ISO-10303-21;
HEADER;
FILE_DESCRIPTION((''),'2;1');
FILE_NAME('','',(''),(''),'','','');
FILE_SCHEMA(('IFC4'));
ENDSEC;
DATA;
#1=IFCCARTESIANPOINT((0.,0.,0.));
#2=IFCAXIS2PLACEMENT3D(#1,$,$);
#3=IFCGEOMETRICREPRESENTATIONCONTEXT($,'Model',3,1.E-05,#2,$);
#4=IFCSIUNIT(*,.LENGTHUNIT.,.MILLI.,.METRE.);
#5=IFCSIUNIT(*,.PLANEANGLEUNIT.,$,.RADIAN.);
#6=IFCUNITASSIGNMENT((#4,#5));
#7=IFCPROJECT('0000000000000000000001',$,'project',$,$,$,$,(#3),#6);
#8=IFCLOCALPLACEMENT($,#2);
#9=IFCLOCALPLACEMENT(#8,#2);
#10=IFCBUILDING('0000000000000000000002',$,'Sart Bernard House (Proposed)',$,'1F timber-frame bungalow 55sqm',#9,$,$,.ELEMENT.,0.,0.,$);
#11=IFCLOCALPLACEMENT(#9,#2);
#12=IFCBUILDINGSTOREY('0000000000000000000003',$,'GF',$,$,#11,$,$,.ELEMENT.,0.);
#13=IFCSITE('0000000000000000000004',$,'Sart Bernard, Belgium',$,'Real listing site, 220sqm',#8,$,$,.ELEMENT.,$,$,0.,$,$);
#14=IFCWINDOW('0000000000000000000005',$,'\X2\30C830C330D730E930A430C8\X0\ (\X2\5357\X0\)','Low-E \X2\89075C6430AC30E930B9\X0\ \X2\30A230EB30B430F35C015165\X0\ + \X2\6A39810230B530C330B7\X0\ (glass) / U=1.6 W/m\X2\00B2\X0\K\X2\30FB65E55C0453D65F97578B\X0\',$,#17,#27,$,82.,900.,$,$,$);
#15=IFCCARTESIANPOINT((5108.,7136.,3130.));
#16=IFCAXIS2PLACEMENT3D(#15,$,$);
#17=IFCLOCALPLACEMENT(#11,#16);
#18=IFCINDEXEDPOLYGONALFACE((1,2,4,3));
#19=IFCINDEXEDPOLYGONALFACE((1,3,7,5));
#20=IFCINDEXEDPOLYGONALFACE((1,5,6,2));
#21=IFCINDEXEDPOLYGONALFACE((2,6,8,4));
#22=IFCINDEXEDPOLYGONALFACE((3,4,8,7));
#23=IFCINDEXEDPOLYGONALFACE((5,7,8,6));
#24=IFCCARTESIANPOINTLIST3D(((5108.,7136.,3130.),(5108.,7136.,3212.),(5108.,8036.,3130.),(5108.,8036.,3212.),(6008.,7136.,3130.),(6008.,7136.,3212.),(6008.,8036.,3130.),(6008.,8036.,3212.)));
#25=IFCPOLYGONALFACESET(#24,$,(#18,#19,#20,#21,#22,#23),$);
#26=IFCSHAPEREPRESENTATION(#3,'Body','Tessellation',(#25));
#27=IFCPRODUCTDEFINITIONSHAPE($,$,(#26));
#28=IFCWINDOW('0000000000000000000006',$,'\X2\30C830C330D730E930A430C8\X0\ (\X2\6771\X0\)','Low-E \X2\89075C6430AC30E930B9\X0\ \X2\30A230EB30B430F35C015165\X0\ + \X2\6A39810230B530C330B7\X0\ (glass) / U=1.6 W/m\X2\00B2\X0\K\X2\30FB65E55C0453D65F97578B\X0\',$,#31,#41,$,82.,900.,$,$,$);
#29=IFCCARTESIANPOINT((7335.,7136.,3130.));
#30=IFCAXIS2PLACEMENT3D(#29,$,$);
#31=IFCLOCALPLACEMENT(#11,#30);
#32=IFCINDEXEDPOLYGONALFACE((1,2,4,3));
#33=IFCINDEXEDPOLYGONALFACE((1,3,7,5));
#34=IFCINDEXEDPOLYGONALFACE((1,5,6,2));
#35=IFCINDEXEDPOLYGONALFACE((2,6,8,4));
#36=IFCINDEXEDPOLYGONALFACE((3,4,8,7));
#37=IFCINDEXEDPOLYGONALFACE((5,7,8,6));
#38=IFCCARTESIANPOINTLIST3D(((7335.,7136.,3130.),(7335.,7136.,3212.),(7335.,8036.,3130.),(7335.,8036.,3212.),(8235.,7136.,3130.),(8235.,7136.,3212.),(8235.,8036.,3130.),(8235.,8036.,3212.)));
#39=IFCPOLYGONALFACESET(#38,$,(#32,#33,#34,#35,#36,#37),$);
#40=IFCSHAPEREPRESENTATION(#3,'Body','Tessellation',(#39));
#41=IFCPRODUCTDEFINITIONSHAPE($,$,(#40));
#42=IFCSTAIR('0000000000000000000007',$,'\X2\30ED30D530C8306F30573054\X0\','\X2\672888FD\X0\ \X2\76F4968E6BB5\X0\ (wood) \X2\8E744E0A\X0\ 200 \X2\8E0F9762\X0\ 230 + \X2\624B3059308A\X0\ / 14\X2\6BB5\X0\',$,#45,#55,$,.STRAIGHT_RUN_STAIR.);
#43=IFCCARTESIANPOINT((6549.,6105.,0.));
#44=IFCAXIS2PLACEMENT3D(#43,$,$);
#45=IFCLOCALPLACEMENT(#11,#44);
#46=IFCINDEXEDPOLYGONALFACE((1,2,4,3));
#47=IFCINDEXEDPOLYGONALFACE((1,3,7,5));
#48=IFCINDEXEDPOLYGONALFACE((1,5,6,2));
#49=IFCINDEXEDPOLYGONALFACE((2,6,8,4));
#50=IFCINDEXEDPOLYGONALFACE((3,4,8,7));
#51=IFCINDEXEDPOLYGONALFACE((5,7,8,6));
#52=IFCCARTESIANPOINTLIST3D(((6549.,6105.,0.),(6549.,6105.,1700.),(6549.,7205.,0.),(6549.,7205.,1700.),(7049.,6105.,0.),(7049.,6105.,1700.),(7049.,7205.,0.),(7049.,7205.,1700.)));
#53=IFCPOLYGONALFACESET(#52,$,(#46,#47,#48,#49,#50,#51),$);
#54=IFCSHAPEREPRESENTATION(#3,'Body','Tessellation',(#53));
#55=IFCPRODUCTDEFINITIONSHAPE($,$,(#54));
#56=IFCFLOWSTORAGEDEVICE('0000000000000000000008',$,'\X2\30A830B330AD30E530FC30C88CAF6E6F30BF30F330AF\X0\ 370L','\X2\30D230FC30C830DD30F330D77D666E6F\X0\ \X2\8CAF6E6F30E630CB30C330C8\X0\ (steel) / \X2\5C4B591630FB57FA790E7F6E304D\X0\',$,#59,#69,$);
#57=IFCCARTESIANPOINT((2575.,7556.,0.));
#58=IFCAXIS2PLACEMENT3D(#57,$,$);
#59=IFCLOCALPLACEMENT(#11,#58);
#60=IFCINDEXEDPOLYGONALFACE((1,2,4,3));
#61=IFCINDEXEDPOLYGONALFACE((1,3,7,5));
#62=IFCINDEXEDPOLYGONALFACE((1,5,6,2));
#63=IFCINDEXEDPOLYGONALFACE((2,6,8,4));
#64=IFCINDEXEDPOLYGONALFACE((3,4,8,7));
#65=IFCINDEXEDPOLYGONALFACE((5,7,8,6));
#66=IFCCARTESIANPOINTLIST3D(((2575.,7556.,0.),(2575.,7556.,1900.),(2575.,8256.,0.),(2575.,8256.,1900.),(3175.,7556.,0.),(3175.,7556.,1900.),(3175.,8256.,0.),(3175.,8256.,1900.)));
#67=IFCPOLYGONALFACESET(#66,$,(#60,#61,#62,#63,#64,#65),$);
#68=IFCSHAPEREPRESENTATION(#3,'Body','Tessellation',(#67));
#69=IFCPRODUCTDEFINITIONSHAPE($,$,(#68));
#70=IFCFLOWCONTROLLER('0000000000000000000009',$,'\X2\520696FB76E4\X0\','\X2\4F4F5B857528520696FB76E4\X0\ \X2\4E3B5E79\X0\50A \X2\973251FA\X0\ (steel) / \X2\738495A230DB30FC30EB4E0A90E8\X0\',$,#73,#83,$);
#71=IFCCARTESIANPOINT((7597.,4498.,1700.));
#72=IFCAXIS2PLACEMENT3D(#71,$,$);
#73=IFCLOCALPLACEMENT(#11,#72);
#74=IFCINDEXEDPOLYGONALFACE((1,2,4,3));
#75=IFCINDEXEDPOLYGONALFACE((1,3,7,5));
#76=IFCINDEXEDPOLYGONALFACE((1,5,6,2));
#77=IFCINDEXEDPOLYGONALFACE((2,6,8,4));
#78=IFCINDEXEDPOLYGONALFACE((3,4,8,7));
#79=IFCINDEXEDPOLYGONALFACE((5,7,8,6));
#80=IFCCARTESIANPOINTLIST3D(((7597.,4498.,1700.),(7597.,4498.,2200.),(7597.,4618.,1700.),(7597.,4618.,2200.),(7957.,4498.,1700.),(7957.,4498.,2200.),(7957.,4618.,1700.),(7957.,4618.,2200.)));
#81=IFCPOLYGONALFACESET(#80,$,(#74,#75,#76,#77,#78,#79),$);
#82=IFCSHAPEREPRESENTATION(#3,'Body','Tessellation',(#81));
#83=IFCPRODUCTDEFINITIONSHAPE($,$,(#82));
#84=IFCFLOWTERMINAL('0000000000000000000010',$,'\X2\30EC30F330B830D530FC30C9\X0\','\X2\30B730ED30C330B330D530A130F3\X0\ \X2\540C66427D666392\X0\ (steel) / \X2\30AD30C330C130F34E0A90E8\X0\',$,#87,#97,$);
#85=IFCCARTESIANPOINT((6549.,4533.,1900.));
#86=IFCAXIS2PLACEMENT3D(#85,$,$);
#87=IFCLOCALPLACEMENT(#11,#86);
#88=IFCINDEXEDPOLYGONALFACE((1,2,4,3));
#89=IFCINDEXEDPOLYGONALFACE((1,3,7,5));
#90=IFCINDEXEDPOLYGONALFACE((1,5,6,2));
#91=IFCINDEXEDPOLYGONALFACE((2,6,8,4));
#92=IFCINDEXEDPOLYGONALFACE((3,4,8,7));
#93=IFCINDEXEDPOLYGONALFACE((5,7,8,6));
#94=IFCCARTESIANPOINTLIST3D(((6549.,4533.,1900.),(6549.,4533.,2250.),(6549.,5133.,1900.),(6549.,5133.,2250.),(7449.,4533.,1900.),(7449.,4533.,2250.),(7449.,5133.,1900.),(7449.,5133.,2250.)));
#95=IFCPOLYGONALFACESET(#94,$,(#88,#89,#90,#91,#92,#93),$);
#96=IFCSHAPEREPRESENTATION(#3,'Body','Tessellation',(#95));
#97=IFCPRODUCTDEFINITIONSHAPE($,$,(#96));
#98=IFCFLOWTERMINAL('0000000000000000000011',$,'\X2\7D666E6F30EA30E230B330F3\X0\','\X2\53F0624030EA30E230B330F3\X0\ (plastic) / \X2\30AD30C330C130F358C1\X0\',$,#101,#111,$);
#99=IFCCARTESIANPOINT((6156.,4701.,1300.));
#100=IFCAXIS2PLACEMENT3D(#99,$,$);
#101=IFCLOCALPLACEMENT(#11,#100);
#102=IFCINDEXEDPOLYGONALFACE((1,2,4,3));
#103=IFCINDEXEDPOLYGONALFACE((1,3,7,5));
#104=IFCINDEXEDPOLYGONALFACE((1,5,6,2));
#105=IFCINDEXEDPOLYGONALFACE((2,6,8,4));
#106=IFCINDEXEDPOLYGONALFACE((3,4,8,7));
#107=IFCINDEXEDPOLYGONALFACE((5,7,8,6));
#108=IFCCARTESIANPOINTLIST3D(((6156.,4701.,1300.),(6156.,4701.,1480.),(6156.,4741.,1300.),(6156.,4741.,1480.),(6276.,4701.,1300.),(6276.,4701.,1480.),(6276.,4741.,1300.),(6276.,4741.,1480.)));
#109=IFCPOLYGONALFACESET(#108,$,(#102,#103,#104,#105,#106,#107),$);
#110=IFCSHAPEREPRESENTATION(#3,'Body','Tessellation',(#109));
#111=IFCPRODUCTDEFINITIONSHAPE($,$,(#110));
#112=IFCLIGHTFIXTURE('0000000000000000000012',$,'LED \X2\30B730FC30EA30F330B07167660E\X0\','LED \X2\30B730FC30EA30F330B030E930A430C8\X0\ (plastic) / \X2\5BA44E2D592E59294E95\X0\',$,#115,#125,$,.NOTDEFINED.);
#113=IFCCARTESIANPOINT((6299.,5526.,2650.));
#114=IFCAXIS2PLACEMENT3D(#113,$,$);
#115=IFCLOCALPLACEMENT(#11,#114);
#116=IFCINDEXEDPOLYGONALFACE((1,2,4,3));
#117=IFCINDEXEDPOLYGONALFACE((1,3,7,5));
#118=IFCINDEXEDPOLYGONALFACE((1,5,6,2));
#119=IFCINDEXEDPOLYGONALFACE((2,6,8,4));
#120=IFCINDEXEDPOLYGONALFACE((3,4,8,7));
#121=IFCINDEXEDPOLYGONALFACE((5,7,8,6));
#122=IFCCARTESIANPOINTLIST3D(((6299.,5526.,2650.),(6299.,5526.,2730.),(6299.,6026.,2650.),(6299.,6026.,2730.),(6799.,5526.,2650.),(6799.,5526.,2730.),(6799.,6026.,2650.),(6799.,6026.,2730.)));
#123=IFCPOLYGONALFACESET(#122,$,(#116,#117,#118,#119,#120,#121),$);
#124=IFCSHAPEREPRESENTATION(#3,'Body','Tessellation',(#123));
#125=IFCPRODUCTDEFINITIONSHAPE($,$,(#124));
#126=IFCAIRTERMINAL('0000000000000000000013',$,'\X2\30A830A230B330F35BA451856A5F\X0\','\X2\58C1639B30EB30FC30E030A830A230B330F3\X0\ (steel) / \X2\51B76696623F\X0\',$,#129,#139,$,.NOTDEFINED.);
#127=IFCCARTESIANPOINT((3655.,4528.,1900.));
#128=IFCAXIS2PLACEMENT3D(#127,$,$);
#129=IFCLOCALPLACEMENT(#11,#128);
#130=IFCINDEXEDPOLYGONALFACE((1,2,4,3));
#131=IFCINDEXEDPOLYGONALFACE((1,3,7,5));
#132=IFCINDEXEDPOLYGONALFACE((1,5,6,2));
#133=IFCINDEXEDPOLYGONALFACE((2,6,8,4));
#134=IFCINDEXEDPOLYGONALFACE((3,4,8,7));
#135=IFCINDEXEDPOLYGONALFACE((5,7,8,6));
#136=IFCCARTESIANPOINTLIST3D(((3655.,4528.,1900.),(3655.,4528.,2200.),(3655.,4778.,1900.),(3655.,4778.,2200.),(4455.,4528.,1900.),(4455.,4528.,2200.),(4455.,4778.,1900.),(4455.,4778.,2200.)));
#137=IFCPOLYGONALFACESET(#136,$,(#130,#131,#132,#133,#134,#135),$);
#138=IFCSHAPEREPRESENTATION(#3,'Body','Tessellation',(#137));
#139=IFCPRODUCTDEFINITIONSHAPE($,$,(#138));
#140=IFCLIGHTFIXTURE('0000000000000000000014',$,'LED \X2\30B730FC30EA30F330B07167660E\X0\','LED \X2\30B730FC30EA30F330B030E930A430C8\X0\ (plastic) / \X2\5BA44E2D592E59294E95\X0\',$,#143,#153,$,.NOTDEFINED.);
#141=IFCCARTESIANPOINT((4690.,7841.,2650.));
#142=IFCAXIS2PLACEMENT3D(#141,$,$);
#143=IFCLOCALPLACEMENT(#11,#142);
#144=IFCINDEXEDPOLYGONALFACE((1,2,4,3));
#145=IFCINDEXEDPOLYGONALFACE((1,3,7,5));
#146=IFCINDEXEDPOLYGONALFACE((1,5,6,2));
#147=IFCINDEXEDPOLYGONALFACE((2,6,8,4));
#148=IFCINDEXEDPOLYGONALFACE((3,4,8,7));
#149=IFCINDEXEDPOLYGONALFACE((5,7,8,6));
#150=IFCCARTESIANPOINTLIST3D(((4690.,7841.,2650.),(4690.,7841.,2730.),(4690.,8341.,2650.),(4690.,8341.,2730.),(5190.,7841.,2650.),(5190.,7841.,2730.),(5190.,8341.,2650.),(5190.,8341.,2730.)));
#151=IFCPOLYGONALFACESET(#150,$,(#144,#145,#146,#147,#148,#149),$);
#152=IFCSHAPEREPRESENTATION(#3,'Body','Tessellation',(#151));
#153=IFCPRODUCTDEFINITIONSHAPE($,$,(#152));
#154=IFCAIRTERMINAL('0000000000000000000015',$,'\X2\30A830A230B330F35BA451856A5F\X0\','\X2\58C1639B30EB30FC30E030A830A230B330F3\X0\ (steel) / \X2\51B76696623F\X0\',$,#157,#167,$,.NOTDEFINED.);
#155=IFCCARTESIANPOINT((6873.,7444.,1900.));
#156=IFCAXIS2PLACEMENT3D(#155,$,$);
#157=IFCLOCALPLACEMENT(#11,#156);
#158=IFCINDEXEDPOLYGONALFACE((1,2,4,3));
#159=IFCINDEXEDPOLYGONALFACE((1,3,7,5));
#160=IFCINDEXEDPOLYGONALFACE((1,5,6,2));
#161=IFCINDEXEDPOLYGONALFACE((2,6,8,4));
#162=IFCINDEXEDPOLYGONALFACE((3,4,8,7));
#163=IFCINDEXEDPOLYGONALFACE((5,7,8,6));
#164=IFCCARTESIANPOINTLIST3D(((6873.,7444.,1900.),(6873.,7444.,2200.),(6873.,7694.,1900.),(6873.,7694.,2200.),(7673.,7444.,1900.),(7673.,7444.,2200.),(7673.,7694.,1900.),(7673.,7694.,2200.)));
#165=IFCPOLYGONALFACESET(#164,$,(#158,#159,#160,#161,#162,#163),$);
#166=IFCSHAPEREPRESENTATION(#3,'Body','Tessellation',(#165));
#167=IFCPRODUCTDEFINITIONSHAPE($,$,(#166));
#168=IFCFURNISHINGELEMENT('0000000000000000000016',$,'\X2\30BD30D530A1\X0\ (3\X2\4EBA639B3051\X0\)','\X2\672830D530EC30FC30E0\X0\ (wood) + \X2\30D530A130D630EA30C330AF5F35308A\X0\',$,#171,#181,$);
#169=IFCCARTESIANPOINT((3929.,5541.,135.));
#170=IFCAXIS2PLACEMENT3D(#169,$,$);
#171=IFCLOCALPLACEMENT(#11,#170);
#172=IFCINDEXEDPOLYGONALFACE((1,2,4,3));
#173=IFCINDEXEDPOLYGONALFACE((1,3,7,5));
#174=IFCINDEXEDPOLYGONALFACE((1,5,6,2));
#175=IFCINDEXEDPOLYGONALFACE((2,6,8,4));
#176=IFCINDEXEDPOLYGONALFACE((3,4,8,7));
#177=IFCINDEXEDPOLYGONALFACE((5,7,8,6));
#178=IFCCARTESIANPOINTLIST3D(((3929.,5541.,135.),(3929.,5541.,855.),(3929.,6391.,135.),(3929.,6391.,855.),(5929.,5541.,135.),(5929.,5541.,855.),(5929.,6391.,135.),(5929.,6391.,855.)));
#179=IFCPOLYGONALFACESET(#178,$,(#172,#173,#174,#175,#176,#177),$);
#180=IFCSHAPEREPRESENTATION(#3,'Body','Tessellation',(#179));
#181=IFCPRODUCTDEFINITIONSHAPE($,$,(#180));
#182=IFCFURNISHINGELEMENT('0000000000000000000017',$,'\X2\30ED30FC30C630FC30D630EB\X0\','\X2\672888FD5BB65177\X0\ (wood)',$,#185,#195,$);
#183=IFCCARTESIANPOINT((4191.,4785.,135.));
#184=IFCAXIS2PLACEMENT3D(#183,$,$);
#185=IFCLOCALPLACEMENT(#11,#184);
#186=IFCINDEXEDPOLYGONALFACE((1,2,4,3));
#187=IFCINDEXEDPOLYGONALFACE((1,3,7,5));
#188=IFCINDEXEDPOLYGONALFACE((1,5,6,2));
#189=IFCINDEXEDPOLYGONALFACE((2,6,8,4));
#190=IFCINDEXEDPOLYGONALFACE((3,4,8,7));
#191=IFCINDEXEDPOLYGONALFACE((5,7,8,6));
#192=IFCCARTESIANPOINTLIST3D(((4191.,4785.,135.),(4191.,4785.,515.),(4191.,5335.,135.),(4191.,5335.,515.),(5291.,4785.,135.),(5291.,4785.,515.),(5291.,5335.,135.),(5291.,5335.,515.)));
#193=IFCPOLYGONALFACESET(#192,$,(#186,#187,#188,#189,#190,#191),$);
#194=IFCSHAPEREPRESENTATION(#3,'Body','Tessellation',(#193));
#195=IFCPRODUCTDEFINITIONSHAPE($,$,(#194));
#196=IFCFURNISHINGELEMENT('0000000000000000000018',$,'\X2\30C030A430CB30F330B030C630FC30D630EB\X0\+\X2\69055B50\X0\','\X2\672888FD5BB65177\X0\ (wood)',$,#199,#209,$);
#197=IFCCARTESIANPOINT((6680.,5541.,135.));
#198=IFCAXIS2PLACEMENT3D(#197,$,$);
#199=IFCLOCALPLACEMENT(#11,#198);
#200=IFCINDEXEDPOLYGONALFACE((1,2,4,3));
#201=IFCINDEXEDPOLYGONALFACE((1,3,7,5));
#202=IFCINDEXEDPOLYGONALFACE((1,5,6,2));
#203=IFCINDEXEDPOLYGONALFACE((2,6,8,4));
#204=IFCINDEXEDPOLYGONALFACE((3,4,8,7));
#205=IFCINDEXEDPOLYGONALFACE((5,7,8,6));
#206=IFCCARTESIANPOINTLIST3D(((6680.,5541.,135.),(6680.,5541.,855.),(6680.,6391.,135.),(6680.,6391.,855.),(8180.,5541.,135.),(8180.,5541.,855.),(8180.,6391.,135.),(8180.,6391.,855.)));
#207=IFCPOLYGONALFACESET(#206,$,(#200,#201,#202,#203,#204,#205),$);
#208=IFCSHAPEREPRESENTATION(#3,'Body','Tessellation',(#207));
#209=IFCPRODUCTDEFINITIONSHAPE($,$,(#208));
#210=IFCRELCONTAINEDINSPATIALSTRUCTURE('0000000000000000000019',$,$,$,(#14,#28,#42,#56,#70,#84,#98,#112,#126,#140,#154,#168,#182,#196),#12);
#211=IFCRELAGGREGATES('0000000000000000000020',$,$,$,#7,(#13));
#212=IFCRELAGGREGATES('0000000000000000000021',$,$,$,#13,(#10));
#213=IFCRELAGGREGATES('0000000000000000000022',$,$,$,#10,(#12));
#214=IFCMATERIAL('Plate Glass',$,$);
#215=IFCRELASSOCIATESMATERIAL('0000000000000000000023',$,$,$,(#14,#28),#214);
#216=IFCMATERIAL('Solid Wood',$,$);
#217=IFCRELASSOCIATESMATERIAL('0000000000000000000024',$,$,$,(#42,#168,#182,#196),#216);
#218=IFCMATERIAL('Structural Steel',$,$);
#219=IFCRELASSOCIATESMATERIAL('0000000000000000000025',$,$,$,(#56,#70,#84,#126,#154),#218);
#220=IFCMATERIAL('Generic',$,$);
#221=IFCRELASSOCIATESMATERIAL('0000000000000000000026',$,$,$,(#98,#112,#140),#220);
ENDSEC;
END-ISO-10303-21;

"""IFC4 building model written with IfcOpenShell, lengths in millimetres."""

from ifc_helpers import new_model, si_unit, frame, frame_2d, origin, place, context, project, spatial, rectangle, extrude, material, element, save


model = new_model("IFC4")

# Units and contexts
model_context = context("Model", 3, precision=1e-05, world=origin())
ifc_project = project(units=[si_unit("LENGTHUNIT", "METRE", prefix="MILLI"), si_unit("PLANEANGLEUNIT", "RADIAN")], contexts=[model_context])

# Site, building, storey
site_placement = place(None, origin())
site = spatial("IfcSite", under=ifc_project, at=site_placement, Name="Sart Bernard, Belgium", ObjectType="Real listing site, 220sqm", CompositionType="ELEMENT", RefElevation=0.0)
building_placement = place(site_placement, origin())
building = spatial("IfcBuilding", under=site, at=building_placement, Name="Sart Bernard House (Proposed)", ObjectType="1F timber-frame bungalow 55sqm", CompositionType="ELEMENT", ElevationOfRefHeight=0.0, ElevationOfTerrain=0.0)
storey_placement = place(building_placement, origin())
storey = spatial("IfcBuildingStorey", under=building, at=storey_placement, Name="GF", CompositionType="ELEMENT", Elevation=0.0)

# Shared definitions
ifc_material_1 = material(Name="Solid Wood")

# Windows
ifc_material_2 = material(Name="Plate Glass")
window_1_placement = place(storey_placement, frame((5108.0, 7136.0, 3130.0)))
element("IfcWindow", 1, at=window_1_placement, inside=storey, material=ifc_material_2, Name="トップライト (南)", Description="Low-E 複層ガラス アルゴン封入 + 樹脂サッシ (glass) / U=1.6 W/m²K・日射取得型", OverallHeight=82.0, OverallWidth=900.0, context=model_context, shape_type="SweptSolid", body=[
    extrude(rectangle(XDim=900.0, YDim=900.0, at=frame_2d((450.0, 450.0))), frame((5108.0, 7136.0, 3130.0)), (0.0, 0.0, 1.0), 82.0),
])
window_2_placement = place(storey_placement, frame((7335.0, 7136.0, 3130.0)))
element("IfcWindow", 2, at=window_2_placement, inside=storey, material=ifc_material_2, Name="トップライト (東)", Description="Low-E 複層ガラス アルゴン封入 + 樹脂サッシ (glass) / U=1.6 W/m²K・日射取得型", OverallHeight=82.0, OverallWidth=900.0, context=model_context, shape_type="SweptSolid", body=[
    extrude(rectangle(XDim=900.0, YDim=900.0, at=frame_2d((450.0, 450.0))), frame((7335.0, 7136.0, 3130.0)), (0.0, 0.0, 1.0), 82.0),
])

# Stair
stair_placement = place(storey_placement, frame((6549.0, 6105.0, 0.0)))
element("IfcStair", 3, at=stair_placement, inside=storey, material=ifc_material_1, Name="ロフトはしご", Description="木製 直階段 (wood) 蹴上 200 踏面 230 + 手すり / 14段", PredefinedType="STRAIGHT_RUN_STAIR", context=model_context, shape_type="SweptSolid", body=[
    extrude(rectangle(XDim=500.0, YDim=1100.0, at=frame_2d((250.0, 550.0))), frame((6549.0, 6105.0, 0.0)), (0.0, 0.0, 1.0), 1700.0),
])

# Flow storage device
ifc_material_3 = material(Name="Structural Steel")
flow_storage_device_placement = place(storey_placement, frame((2575.0, 7556.0, 0.0)))
element("IfcFlowStorageDevice", 4, at=flow_storage_device_placement, inside=storey, material=ifc_material_3, Name="エコキュート貯湯タンク 370L", Description="ヒートポンプ給湯 貯湯ユニット (steel) / 屋外・基礎置き", context=model_context, shape_type="SweptSolid", body=[
    extrude(rectangle(XDim=600.0, YDim=700.0, at=frame_2d((300.0, 350.0))), frame((2575.0, 7556.0, 0.0)), (0.0, 0.0, 1.0), 1900.0),
])

# Flow controller
flow_controller_placement = place(storey_placement, frame((7597.0, 4498.0, 1700.0)))
element("IfcFlowController", 5, at=flow_controller_placement, inside=storey, material=ifc_material_3, Name="分電盤", Description="住宅用分電盤 主幹50A 露出 (steel) / 玄関ホール上部", context=model_context, shape_type="SweptSolid", body=[
    extrude(rectangle(XDim=360.0, YDim=120.0, at=frame_2d((180.0, 60.0))), frame((7597.0, 4498.0, 1700.0)), (0.0, 0.0, 1.0), 500.0),
])

# Flow terminals
flow_terminal_1_placement = place(storey_placement, frame((6549.0, 4533.0, 1900.0)))
element("IfcFlowTerminal", 6, at=flow_terminal_1_placement, inside=storey, material=ifc_material_3, Name="レンジフード", Description="シロッコファン 同時給排 (steel) / キッチン上部", context=model_context, shape_type="SweptSolid", body=[
    extrude(rectangle(XDim=900.0, YDim=600.0, at=frame_2d((450.0, 300.0))), frame((6549.0, 4533.0, 1900.0)), (0.0, 0.0, 1.0), 350.0),
])
ifc_material_4 = material(Name="Generic")
flow_terminal_2_placement = place(storey_placement, frame((6156.0, 4701.0, 1300.0)))
element("IfcFlowTerminal", 7, at=flow_terminal_2_placement, inside=storey, material=ifc_material_4, Name="給湯リモコン", Description="台所リモコン (plastic) / キッチン壁", context=model_context, shape_type="SweptSolid", body=[
    extrude(rectangle(XDim=120.0, YDim=40.0, at=frame_2d((60.0, 20.0))), frame((6156.0, 4701.0, 1300.0)), (0.0, 0.0, 1.0), 180.0),
])

# Light fixture
light_fixture_1_placement = place(storey_placement, frame((6299.0, 5526.0, 2650.0)))
element("IfcLightFixture", 8, at=light_fixture_1_placement, inside=storey, material=ifc_material_4, Name="LED シーリング照明", Description="LED シーリングライト (plastic) / 室中央天井", PredefinedType="NOTDEFINED", context=model_context, shape_type="SweptSolid", body=[
    extrude(rectangle(XDim=500.0, YDim=500.0, at=frame_2d((250.0, 250.0))), frame((6299.0, 5526.0, 2650.0)), (0.0, 0.0, 1.0), 80.0),
])

# Air terminal
air_terminal_1_placement = place(storey_placement, frame((3655.0, 4528.0, 1900.0)))
element("IfcAirTerminal", 9, at=air_terminal_1_placement, inside=storey, material=ifc_material_3, Name="エアコン室内機", Description="壁掛ルームエアコン (steel) / 冷暖房", PredefinedType="NOTDEFINED", context=model_context, shape_type="SweptSolid", body=[
    extrude(rectangle(XDim=800.0, YDim=250.0, at=frame_2d((400.0, 125.0))), frame((3655.0, 4528.0, 1900.0)), (0.0, 0.0, 1.0), 300.0),
])

# Light fixture
light_fixture_2_placement = place(storey_placement, frame((4690.0, 7841.0, 2650.0)))
element("IfcLightFixture", 10, at=light_fixture_2_placement, inside=storey, material=ifc_material_4, Name="LED シーリング照明", Description="LED シーリングライト (plastic) / 室中央天井", PredefinedType="NOTDEFINED", context=model_context, shape_type="SweptSolid", body=[
    extrude(rectangle(XDim=500.0, YDim=500.0, at=frame_2d((250.0, 250.0))), frame((4690.0, 7841.0, 2650.0)), (0.0, 0.0, 1.0), 80.0),
])

# Air terminal
air_terminal_2_placement = place(storey_placement, frame((6873.0, 7444.0, 1900.0)))
element("IfcAirTerminal", 11, at=air_terminal_2_placement, inside=storey, material=ifc_material_3, Name="エアコン室内機", Description="壁掛ルームエアコン (steel) / 冷暖房", PredefinedType="NOTDEFINED", context=model_context, shape_type="SweptSolid", body=[
    extrude(rectangle(XDim=800.0, YDim=250.0, at=frame_2d((400.0, 125.0))), frame((6873.0, 7444.0, 1900.0)), (0.0, 0.0, 1.0), 300.0),
])

# Furnishing elements
furnishing_1_placement = place(storey_placement, frame((3929.0, 5541.0, 135.0)))
element("IfcFurnishingElement", 12, at=furnishing_1_placement, inside=storey, material=ifc_material_1, Name="ソファ (3人掛け)", Description="木フレーム (wood) + ファブリック張り", context=model_context, shape_type="SweptSolid", body=[
    extrude(rectangle(XDim=2000.0, YDim=850.0, at=frame_2d((1000.0, 425.0))), frame((3929.0, 5541.0, 135.0)), (0.0, 0.0, 1.0), 720.0),
])
furnishing_2_placement = place(storey_placement, frame((4191.0, 4785.0, 135.0)))
element("IfcFurnishingElement", 13, at=furnishing_2_placement, inside=storey, material=ifc_material_1, Name="ローテーブル", Description="木製家具 (wood)", context=model_context, shape_type="SweptSolid", body=[
    extrude(rectangle(XDim=1100.0, YDim=550.0, at=frame_2d((550.0, 275.0))), frame((4191.0, 4785.0, 135.0)), (0.0, 0.0, 1.0), 380.0),
])
furnishing_3_placement = place(storey_placement, frame((6680.0, 5541.0, 135.0)))
element("IfcFurnishingElement", 14, at=furnishing_3_placement, inside=storey, material=ifc_material_1, Name="ダイニングテーブル+椅子", Description="木製家具 (wood)", context=model_context, shape_type="SweptSolid", body=[
    extrude(rectangle(XDim=1500.0, YDim=850.0, at=frame_2d((750.0, 425.0))), frame((6680.0, 5541.0, 135.0)), (0.0, 0.0, 1.0), 720.0),
])

save(model, "model.ifc")
